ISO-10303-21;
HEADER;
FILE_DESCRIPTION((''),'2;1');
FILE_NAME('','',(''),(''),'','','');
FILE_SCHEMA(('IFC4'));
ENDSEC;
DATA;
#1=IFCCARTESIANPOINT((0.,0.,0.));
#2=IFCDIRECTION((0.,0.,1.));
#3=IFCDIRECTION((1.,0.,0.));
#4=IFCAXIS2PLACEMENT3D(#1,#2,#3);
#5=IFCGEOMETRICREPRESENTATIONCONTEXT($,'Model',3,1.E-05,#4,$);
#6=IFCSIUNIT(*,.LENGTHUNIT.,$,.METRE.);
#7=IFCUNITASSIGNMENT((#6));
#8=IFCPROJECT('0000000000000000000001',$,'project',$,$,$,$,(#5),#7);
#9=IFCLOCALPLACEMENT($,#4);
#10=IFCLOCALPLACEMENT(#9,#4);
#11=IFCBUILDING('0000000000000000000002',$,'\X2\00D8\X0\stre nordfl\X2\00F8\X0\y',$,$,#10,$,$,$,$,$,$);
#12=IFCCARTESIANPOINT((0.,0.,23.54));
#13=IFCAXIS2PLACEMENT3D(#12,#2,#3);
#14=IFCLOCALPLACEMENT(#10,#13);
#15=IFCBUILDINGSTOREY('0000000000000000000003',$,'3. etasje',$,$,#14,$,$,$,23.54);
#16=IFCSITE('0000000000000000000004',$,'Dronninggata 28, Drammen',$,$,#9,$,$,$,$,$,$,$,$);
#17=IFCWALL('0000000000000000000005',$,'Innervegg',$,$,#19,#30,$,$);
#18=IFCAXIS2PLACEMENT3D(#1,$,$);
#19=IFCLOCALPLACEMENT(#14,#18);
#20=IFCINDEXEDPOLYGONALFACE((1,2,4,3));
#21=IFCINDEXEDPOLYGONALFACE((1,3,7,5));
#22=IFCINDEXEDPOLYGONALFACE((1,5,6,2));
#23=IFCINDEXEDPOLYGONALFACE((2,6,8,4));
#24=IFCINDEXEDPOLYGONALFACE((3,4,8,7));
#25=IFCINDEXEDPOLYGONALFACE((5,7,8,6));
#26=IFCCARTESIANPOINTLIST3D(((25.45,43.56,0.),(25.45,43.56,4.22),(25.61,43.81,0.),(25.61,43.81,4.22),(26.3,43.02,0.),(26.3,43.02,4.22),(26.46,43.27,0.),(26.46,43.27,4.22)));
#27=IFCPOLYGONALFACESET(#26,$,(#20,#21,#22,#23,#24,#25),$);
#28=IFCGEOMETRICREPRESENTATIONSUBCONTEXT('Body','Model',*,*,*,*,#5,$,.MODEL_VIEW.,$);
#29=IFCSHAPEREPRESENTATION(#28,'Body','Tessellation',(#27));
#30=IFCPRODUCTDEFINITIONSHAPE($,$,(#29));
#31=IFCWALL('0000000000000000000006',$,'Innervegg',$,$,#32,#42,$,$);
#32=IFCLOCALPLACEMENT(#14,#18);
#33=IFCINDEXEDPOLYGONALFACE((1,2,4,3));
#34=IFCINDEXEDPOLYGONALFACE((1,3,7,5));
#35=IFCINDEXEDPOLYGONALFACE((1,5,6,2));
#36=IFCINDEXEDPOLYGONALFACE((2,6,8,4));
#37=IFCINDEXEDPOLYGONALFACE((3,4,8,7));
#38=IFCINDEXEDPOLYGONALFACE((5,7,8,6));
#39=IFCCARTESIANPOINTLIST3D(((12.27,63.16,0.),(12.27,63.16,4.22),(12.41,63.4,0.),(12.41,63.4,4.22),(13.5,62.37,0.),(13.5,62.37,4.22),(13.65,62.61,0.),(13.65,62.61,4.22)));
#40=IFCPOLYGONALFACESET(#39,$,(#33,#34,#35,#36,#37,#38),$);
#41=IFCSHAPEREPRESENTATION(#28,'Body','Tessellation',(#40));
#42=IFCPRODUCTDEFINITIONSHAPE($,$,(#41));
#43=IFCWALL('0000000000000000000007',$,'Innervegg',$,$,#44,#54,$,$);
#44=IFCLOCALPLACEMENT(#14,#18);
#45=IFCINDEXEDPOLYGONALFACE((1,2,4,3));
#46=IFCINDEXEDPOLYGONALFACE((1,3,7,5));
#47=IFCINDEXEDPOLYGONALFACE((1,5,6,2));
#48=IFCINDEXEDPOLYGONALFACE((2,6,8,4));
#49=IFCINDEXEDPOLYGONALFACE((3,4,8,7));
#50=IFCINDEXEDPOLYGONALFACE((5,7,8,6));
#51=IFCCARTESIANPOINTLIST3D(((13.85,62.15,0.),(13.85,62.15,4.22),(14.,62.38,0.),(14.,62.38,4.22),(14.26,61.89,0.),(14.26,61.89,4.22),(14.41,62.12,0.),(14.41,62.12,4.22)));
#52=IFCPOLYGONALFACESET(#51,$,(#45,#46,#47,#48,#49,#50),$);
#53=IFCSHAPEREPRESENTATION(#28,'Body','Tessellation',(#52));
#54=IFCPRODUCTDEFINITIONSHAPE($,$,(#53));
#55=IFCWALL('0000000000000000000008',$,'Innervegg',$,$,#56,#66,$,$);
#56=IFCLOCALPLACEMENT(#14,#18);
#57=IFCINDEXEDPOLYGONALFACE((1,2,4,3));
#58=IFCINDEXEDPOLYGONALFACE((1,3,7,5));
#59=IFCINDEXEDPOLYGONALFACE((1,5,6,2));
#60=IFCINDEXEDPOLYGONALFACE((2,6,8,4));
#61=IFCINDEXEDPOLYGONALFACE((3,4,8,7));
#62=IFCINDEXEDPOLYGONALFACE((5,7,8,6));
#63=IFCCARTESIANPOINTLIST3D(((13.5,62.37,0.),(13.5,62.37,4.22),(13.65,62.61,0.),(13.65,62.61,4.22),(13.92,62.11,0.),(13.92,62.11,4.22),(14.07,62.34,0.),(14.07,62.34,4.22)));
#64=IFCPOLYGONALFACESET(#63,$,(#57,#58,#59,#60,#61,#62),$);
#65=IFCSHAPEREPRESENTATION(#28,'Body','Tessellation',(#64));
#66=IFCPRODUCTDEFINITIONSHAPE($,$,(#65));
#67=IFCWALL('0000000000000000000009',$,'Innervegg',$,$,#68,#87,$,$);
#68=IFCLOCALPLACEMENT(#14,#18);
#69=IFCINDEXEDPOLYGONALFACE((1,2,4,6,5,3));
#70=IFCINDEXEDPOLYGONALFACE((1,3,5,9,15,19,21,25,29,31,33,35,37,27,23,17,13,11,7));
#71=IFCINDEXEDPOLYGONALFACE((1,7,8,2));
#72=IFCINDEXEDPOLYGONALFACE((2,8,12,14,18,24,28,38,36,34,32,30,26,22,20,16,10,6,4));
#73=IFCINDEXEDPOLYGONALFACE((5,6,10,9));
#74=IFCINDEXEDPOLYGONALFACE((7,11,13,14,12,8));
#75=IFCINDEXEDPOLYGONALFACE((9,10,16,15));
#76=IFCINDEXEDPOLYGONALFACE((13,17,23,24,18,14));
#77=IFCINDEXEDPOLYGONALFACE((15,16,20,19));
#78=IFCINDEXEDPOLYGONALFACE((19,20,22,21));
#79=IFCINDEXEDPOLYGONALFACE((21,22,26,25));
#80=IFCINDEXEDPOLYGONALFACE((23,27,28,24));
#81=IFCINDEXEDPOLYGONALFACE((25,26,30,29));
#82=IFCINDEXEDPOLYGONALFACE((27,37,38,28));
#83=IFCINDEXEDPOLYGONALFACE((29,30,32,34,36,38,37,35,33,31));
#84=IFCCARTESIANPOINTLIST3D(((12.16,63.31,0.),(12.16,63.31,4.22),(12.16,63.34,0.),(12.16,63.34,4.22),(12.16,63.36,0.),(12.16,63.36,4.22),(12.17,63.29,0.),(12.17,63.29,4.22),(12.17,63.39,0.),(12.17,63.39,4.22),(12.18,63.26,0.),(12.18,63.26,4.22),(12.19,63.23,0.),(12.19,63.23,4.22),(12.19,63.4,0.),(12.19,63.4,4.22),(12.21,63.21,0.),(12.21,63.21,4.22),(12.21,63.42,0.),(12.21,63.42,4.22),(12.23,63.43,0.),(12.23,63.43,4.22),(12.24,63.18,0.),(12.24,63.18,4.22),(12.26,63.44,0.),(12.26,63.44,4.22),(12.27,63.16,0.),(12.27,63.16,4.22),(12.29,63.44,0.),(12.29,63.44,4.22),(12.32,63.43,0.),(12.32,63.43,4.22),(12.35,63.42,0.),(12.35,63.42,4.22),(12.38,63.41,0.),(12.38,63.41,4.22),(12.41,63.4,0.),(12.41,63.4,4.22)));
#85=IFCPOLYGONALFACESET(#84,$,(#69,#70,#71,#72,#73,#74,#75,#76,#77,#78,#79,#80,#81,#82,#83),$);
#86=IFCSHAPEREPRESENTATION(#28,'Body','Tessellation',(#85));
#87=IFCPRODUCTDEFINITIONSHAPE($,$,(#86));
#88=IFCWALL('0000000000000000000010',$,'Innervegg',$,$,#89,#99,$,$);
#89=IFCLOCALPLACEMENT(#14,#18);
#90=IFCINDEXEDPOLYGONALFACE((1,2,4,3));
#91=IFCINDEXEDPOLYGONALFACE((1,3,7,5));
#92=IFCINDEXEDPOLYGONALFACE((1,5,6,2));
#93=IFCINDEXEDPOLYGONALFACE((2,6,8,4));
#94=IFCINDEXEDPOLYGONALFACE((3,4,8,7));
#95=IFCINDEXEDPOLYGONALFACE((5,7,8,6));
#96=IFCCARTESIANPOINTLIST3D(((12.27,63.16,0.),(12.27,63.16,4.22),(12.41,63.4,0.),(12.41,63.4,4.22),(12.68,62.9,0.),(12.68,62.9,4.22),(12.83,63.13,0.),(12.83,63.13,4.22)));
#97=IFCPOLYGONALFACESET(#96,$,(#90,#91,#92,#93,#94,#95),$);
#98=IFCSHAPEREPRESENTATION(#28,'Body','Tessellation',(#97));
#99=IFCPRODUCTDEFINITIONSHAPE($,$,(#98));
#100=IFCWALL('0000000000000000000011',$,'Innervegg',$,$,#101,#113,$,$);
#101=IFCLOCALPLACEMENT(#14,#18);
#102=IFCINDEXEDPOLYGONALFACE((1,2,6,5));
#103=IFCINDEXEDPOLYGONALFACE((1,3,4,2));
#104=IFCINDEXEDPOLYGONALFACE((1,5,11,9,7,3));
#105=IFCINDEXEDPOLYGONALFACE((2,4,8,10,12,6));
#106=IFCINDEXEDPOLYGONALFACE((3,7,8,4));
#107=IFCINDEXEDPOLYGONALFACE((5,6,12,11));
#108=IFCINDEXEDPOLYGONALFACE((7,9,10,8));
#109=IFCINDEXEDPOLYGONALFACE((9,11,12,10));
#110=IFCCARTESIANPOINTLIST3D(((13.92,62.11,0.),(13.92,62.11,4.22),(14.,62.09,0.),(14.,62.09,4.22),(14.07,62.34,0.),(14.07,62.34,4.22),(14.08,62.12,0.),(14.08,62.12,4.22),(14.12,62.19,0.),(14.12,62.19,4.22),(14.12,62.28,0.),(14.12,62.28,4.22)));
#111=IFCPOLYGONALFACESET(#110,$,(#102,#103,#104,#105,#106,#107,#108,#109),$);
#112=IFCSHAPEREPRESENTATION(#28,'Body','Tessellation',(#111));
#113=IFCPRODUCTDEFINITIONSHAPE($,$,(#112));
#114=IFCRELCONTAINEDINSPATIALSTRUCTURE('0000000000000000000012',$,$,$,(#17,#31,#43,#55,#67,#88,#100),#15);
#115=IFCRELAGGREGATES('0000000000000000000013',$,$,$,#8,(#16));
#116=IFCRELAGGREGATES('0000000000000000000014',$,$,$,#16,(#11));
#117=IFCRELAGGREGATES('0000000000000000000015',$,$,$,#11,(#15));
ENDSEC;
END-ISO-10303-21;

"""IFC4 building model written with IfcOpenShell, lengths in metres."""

from ifc_helpers import new_model, si_unit, frame, origin_with_axes, place, context, subcontext, project, spatial, polyline, outline, extrude, element, save


model = new_model("IFC4")

# Units and contexts
model_context = context("Model", 3, precision=1e-05, world=origin_with_axes())
body_context = subcontext(model_context, "Body", "Model", "MODEL_VIEW")
ifc_project = project(units=[si_unit("LENGTHUNIT", "METRE")], contexts=[model_context])

# Site, building, storey
site_placement = place(None, origin_with_axes())
site = spatial("IfcSite", under=ifc_project, at=site_placement, Name="Dronninggata 28, Drammen")
building_placement = place(site_placement, origin_with_axes())
building = spatial("IfcBuilding", under=site, at=building_placement, Name="Østre nordfløy")
storey_placement = place(building_placement, frame((0.0, 0.0, 23.54), z_axis=(0.0, 0.0, 1.0), x_axis=(1.0, 0.0, 0.0)))
storey = spatial("IfcBuildingStorey", under=building, at=storey_placement, Name="3. etasje", Elevation=23.54)

# Walls
wall_1_placement = place(storey_placement, frame((0.0, 0.0, -23.54), z_axis=(0.0, 0.0, 1.0), x_axis=(1.0, 0.0, 0.0)))
element("IfcWall", 1, at=wall_1_placement, inside=storey, Name="Innervegg", context=body_context, shape_type="SweptSolid", body=[
    extrude(outline(polyline([(26.3, 43.02), (25.45, 43.56), (25.61, 43.81), (26.46, 43.27), (26.3, 43.02)])), frame((0.0, 0.0, 23.54)), (0.0, 0.0, 1.0), 4.22),
])
wall_2_placement = place(storey_placement, frame((0.0, 0.0, -23.54), z_axis=(0.0, 0.0, 1.0), x_axis=(1.0, 0.0, 0.0)))
element("IfcWall", 2, at=wall_2_placement, inside=storey, Name="Innervegg", context=body_context, shape_type="SweptSolid", body=[
    extrude(outline(polyline([(12.41, 63.4), (13.65, 62.61), (13.5, 62.37), (12.27, 63.16), (12.41, 63.4)])), frame((0.0, 0.0, 23.54)), (0.0, 0.0, 1.0), 4.22),
])
wall_3_placement = place(storey_placement, frame((0.0, 0.0, -23.54), z_axis=(0.0, 0.0, 1.0), x_axis=(1.0, 0.0, 0.0)))
element("IfcWall", 3, at=wall_3_placement, inside=storey, Name="Innervegg", context=body_context, shape_type="SweptSolid", body=[
    extrude(outline(polyline([(14.26, 61.89), (13.85, 62.15), (14.0, 62.38), (14.41, 62.12), (14.26, 61.89)])), frame((0.0, 0.0, 23.54)), (0.0, 0.0, 1.0), 4.22),
])
wall_4_placement = place(storey_placement, frame((0.0, 0.0, -23.54), z_axis=(0.0, 0.0, 1.0), x_axis=(1.0, 0.0, 0.0)))
element("IfcWall", 4, at=wall_4_placement, inside=storey, Name="Innervegg", context=body_context, shape_type="SweptSolid", body=[
    extrude(outline(polyline([(13.65, 62.61), (14.07, 62.34), (13.92, 62.11), (13.5, 62.37), (13.65, 62.61)])), frame((0.0, 0.0, 23.54)), (0.0, 0.0, 1.0), 4.22),
])
wall_5_placement = place(storey_placement, frame((0.0, 0.0, -23.54), z_axis=(0.0, 0.0, 1.0), x_axis=(1.0, 0.0, 0.0)))
element("IfcWall", 5, at=wall_5_placement, inside=storey, Name="Innervegg", context=body_context, shape_type="SweptSolid", body=[
    extrude(outline(polyline([(12.27, 63.16), (12.41, 63.4), (12.38, 63.41), (12.35, 63.42), (12.32, 63.43), (12.29, 63.44), (12.26, 63.44), (12.23, 63.43), (12.21, 63.42), (12.19, 63.4), (12.17, 63.39), (12.16, 63.36), (12.16, 63.34), (12.16, 63.31), (12.17, 63.29), (12.18, 63.26), (12.19, 63.23), (12.21, 63.21), (12.24, 63.18), (12.27, 63.16)])), frame((0.0, 0.0, 23.54)), (0.0, 0.0, 1.0), 4.22),
])
wall_6_placement = place(storey_placement, frame((0.0, 0.0, -23.54), z_axis=(0.0, 0.0, 1.0), x_axis=(1.0, 0.0, 0.0)))
element("IfcWall", 6, at=wall_6_placement, inside=storey, Name="Innervegg", context=body_context, shape_type="SweptSolid", body=[
    extrude(outline(polyline([(12.83, 63.13), (12.41, 63.4), (12.27, 63.16), (12.68, 62.9), (12.83, 63.13)])), frame((0.0, 0.0, 23.54)), (0.0, 0.0, 1.0), 4.22),
])
wall_7_placement = place(storey_placement, frame((0.0, 0.0, -23.54), z_axis=(0.0, 0.0, 1.0), x_axis=(1.0, 0.0, 0.0)))
element("IfcWall", 7, at=wall_7_placement, inside=storey, Name="Innervegg", context=body_context, shape_type="SweptSolid", body=[
    extrude(outline(polyline([(14.07, 62.34), (13.92, 62.11), (14.0, 62.09), (14.08, 62.12), (14.12, 62.19), (14.12, 62.28), (14.07, 62.34)])), frame((0.0, 0.0, 23.54)), (0.0, 0.0, 1.0), 4.22),
])

save(model, "model.ifc")
